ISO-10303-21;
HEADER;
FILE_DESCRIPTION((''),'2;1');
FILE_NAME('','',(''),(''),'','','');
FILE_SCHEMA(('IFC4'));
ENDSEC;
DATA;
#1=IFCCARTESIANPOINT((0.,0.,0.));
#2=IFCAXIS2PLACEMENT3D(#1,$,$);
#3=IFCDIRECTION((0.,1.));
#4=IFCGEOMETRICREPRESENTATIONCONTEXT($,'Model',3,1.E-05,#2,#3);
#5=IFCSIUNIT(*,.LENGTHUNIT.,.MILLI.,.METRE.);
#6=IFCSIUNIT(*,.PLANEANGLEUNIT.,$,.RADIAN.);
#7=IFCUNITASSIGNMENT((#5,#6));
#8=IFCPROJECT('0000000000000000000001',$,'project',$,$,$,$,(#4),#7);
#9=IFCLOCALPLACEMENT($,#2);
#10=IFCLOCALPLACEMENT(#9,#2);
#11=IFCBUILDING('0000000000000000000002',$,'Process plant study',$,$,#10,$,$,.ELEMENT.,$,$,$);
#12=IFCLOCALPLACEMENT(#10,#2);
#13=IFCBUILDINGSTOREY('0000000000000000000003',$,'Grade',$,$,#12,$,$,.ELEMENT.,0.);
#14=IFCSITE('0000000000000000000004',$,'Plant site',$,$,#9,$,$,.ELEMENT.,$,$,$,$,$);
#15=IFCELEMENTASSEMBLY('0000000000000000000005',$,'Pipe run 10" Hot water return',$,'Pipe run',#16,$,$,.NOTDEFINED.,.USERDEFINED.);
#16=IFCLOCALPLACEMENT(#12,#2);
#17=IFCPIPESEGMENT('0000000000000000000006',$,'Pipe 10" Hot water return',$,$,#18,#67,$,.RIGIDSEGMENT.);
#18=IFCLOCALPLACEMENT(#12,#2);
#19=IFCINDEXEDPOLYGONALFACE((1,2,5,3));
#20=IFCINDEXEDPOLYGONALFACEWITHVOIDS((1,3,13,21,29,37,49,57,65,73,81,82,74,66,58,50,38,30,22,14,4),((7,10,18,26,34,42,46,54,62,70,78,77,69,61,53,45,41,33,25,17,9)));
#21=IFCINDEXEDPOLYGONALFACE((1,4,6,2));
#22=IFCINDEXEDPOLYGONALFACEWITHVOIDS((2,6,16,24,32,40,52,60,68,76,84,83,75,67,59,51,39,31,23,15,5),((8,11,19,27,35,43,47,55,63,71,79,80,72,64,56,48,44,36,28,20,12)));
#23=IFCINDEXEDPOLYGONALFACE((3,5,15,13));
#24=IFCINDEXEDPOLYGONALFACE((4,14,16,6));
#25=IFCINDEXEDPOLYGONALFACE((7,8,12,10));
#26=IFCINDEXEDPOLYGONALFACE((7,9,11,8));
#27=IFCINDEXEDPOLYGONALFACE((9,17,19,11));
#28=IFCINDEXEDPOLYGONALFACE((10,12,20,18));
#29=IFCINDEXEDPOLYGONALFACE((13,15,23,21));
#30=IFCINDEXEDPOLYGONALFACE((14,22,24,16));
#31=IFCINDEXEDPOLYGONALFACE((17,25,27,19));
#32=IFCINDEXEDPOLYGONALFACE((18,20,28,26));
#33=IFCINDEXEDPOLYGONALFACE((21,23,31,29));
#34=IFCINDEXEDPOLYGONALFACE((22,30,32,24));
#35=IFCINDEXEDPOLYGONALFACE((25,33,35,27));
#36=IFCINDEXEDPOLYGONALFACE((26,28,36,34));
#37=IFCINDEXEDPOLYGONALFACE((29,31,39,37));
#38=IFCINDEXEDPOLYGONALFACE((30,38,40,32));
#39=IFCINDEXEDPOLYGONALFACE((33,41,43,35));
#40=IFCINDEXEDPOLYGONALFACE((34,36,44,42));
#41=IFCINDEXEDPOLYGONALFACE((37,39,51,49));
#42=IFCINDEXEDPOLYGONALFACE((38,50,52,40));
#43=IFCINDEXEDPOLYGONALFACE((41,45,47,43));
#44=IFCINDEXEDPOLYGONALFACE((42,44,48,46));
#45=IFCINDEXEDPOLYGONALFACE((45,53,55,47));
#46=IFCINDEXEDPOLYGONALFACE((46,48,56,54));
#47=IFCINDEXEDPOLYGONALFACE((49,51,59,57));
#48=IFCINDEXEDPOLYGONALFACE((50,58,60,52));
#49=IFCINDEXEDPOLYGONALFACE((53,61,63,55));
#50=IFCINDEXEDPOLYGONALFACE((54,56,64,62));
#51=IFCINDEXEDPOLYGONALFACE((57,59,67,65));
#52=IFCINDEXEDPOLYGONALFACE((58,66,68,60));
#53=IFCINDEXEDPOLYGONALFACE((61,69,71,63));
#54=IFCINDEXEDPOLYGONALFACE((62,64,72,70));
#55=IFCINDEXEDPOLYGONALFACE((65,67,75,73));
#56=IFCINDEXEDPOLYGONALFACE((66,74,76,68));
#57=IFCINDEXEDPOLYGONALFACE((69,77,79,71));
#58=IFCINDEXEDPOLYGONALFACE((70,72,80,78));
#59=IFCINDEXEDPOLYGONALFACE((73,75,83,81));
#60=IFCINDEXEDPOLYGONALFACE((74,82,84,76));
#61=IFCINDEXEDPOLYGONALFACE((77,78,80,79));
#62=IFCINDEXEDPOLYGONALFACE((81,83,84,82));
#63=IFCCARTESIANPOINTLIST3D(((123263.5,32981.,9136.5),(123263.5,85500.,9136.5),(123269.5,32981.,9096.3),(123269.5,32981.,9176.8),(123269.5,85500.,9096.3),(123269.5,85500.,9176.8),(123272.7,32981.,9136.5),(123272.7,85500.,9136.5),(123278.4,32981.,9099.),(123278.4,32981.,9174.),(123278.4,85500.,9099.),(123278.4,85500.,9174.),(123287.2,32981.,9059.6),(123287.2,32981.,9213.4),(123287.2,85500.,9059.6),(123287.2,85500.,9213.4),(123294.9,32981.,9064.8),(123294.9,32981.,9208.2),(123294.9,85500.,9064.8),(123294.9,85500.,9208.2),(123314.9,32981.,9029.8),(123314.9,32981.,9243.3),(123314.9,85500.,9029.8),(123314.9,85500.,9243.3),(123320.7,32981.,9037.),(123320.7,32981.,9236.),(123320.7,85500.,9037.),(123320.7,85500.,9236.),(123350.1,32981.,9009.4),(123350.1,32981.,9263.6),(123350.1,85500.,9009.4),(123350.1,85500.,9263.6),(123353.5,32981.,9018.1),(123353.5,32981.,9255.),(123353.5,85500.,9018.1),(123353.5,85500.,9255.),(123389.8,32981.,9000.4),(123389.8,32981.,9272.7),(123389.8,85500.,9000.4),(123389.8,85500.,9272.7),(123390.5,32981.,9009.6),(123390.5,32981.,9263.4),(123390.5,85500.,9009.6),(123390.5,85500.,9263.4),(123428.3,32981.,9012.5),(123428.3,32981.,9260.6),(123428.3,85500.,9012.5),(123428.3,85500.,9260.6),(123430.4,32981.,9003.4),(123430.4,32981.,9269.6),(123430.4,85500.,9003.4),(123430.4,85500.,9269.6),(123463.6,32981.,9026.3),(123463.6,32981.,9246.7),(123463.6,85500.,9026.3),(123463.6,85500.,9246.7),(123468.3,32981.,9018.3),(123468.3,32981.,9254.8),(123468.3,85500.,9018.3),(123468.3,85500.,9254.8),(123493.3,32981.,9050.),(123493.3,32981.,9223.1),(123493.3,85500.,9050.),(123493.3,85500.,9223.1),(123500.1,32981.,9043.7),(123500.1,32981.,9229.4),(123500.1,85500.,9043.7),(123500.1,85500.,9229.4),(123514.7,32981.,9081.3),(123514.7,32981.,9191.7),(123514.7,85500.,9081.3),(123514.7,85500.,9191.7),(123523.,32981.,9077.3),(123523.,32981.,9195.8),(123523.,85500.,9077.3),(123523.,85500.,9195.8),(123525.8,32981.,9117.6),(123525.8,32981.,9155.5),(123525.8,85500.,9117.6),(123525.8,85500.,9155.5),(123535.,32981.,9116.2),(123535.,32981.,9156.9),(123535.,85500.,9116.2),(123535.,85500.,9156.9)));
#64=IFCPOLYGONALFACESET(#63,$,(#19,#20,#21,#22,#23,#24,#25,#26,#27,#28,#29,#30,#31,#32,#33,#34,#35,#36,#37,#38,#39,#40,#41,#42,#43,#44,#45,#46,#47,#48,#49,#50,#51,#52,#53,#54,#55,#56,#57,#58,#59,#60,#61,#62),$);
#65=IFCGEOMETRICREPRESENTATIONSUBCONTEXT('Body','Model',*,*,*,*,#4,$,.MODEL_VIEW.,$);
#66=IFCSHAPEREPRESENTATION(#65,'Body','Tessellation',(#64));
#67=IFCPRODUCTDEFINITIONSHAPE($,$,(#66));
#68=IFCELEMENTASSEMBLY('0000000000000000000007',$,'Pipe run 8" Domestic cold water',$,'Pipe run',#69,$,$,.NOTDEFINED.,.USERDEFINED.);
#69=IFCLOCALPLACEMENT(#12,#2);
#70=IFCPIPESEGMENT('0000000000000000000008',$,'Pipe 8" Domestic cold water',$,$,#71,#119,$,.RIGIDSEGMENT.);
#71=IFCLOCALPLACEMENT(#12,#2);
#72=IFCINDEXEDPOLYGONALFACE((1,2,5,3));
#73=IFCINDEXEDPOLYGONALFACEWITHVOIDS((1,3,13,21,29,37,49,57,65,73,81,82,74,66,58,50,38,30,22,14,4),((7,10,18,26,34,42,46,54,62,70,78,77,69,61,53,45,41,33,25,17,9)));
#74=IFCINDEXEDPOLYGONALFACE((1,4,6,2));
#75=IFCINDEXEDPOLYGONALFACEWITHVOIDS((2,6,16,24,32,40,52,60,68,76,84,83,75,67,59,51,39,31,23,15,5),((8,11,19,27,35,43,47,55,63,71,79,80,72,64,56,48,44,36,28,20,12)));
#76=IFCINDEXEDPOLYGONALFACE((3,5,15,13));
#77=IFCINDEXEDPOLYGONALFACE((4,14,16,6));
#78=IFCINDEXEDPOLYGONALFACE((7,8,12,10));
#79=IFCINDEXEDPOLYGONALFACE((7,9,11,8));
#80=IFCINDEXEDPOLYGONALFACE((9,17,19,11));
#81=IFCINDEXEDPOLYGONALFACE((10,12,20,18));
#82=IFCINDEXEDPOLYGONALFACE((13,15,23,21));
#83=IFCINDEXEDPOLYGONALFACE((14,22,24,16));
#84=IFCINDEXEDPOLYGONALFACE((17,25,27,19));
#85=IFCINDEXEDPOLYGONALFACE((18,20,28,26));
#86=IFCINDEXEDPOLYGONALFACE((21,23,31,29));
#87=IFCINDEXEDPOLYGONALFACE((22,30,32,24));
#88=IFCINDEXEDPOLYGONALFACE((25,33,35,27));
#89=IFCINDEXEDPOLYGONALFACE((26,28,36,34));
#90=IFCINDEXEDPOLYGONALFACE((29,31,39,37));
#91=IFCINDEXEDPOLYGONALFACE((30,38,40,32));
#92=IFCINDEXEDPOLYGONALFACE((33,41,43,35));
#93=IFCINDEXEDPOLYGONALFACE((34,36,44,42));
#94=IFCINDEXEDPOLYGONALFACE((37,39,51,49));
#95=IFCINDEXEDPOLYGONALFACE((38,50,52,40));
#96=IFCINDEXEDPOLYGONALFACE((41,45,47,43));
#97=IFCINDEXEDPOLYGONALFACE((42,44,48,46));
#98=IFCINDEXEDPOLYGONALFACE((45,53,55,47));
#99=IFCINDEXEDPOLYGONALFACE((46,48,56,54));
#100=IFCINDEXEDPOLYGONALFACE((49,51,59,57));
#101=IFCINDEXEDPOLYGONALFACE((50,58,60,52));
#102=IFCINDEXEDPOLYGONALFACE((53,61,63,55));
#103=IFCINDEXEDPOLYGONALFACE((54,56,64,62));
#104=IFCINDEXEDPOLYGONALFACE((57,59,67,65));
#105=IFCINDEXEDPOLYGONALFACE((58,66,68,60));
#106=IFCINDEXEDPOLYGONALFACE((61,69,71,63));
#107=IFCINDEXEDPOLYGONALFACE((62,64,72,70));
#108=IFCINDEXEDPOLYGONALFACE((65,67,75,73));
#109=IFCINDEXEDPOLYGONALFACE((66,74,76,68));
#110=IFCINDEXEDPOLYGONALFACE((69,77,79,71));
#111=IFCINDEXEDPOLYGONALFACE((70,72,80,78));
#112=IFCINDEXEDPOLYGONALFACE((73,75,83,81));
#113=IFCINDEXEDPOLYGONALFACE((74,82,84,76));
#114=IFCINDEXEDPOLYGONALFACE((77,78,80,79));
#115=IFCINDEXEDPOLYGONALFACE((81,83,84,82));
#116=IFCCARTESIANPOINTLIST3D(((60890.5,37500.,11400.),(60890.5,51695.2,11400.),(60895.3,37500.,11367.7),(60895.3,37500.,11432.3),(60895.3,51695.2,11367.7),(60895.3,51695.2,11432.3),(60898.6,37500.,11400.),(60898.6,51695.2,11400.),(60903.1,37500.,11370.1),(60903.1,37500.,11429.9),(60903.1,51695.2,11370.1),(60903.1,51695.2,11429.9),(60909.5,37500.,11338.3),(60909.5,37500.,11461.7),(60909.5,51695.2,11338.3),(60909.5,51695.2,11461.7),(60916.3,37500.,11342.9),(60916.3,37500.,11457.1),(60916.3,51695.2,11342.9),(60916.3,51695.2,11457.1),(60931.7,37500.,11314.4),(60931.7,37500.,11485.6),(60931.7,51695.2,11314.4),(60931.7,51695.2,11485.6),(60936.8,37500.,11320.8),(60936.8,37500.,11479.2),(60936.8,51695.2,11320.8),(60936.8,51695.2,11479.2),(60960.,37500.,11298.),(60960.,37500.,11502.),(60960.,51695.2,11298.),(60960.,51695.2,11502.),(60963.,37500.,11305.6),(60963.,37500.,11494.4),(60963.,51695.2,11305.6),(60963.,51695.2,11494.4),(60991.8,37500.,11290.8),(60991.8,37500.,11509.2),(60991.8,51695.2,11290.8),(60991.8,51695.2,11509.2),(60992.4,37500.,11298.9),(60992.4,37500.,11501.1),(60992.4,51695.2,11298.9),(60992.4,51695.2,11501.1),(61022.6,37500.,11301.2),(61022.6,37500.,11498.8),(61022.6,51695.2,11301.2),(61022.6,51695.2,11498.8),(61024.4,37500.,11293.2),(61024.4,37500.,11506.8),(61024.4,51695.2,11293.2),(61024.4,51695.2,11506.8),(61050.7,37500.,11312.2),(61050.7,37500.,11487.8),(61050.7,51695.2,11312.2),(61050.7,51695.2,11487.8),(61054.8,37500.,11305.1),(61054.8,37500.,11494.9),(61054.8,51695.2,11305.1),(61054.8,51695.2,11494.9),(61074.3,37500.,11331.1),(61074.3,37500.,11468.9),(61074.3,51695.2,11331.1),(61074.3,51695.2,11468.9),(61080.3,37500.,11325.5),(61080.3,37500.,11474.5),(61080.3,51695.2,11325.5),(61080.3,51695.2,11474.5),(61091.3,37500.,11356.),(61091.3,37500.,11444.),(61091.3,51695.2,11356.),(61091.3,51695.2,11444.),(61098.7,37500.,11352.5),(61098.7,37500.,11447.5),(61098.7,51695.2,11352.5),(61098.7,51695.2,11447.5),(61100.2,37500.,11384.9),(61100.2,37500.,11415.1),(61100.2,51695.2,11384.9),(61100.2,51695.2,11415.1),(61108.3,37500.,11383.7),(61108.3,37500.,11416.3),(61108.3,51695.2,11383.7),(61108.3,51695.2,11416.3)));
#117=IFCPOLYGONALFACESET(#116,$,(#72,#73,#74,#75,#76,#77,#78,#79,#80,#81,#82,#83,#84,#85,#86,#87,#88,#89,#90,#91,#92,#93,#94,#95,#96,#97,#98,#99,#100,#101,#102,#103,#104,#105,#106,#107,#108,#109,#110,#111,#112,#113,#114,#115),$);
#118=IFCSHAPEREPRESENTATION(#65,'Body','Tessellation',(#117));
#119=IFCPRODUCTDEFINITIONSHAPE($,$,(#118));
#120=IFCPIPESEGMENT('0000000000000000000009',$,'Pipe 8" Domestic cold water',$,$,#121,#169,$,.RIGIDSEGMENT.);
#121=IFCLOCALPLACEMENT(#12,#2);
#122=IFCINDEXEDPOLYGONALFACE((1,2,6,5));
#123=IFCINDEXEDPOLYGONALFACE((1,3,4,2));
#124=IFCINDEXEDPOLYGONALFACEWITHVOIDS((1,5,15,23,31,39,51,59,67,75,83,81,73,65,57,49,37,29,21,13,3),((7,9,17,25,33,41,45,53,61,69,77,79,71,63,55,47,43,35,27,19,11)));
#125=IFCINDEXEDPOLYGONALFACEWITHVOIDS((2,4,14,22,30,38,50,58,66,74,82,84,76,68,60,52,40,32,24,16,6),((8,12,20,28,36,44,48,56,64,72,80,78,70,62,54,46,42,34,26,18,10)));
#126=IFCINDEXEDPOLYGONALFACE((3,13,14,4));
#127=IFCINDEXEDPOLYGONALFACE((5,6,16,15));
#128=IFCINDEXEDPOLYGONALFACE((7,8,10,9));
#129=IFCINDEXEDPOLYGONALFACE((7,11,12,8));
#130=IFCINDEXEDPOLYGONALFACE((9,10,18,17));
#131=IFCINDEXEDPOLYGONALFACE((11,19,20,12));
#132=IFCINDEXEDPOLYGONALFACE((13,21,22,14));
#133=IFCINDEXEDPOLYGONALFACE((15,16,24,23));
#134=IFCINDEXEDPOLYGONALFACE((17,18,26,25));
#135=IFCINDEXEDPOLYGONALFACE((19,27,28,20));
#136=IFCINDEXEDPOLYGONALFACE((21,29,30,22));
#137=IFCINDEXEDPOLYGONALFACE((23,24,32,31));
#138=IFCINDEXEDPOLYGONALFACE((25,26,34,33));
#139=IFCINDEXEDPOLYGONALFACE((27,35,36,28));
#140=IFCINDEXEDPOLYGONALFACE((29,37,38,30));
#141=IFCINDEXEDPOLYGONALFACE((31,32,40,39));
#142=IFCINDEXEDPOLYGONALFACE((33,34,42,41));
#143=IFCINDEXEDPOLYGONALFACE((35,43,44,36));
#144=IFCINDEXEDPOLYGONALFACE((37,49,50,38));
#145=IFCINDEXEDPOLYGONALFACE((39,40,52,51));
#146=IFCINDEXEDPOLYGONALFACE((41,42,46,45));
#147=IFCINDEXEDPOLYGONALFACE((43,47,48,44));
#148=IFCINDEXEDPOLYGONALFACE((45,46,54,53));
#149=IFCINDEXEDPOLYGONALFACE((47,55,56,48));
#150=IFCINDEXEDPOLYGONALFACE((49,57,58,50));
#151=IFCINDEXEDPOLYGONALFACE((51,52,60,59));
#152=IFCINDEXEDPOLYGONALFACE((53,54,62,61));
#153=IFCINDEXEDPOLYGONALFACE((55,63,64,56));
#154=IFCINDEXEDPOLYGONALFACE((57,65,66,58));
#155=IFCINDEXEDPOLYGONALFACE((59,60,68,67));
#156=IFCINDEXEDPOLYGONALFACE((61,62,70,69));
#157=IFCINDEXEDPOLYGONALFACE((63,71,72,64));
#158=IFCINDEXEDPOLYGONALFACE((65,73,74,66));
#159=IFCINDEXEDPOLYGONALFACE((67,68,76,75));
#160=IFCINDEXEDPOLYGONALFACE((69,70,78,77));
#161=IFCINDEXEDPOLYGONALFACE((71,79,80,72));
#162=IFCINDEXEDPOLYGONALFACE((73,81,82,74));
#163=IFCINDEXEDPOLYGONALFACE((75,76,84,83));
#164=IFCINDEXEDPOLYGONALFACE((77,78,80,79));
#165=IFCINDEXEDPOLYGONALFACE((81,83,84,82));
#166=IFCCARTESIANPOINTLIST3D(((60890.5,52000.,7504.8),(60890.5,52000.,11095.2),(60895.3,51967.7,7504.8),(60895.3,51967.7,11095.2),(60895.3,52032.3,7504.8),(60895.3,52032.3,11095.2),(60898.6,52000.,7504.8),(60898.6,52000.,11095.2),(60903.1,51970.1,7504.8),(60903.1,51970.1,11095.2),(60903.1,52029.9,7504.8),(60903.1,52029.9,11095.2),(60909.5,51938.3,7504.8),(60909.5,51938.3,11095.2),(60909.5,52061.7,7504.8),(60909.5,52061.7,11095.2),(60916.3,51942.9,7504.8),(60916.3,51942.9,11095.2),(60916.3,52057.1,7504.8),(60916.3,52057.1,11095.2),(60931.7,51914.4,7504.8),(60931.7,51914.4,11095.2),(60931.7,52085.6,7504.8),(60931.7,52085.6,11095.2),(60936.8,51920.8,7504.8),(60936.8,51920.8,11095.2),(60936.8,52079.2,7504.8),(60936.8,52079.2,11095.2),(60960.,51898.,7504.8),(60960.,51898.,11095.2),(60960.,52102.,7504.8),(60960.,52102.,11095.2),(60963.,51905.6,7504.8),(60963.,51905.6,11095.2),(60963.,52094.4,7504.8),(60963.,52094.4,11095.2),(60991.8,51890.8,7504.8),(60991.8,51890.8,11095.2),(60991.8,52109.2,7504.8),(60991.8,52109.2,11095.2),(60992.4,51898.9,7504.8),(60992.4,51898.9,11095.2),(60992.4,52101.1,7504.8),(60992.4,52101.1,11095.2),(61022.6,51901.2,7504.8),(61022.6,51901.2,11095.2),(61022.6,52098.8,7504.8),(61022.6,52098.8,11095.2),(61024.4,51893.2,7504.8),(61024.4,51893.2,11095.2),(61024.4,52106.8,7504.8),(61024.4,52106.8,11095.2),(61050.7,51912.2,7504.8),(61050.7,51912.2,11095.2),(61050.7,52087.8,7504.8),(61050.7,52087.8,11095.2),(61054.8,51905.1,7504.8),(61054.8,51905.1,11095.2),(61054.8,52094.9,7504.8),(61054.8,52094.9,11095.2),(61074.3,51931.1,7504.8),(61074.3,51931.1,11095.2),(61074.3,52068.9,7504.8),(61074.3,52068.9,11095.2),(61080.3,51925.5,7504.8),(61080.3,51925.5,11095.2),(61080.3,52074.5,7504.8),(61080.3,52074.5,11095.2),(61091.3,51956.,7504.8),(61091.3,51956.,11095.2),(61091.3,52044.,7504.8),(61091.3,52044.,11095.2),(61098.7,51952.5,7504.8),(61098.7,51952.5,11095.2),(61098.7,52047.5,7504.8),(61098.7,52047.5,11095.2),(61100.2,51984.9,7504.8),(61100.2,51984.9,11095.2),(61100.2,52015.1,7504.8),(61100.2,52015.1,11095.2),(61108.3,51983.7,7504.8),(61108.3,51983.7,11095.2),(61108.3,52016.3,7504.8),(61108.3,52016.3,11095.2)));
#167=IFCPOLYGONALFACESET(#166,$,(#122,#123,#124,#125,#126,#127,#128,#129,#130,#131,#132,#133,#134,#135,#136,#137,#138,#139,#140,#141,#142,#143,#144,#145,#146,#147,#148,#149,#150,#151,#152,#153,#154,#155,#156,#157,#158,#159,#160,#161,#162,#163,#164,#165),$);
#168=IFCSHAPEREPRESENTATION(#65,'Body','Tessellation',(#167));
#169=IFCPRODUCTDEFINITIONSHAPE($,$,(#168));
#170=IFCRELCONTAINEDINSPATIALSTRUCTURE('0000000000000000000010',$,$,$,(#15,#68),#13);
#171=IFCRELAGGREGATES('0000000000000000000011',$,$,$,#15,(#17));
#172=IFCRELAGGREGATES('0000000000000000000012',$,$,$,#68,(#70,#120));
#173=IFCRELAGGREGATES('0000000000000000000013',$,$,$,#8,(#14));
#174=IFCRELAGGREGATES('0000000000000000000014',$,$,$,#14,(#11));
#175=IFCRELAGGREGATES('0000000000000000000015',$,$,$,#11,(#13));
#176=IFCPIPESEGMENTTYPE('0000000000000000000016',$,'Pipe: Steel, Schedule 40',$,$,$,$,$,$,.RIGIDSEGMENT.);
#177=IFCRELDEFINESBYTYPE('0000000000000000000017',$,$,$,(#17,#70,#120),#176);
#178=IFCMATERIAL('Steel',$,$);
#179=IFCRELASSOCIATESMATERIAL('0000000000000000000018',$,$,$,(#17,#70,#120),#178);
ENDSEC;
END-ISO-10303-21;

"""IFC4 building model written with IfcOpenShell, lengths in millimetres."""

from ifc_helpers import new_model, si_unit, direction, frame, origin, origin_with_axes, origin_2d, place, context, subcontext, project, spatial, hollow_circle, extrude, material, type_object, element, aggregate, save


model = new_model("IFC4")

# Units and contexts
model_context = context("Model", 3, precision=1e-05, world=origin(), true_north=direction((0.0, 1.0)))
body_context = subcontext(model_context, "Body", "Model", "MODEL_VIEW")
ifc_project = project(units=[si_unit("LENGTHUNIT", "METRE", prefix="MILLI"), si_unit("PLANEANGLEUNIT", "RADIAN")], contexts=[model_context])

# Site, building, storey
site_placement = place(None, origin())
site = spatial("IfcSite", under=ifc_project, at=site_placement, Name="Plant site", CompositionType="ELEMENT")
building_placement = place(site_placement, origin())
building = spatial("IfcBuilding", under=site, at=building_placement, Name="Process plant study", CompositionType="ELEMENT")
storey_placement = place(building_placement, origin())
storey = spatial("IfcBuildingStorey", under=building, at=storey_placement, Name="Grade", CompositionType="ELEMENT", Elevation=0.0)

# Shared definitions
ifc_material = material(Name="Steel")
pipe_segment_type = type_object("IfcPipeSegmentType", Name="Pipe: Steel, Schedule 40", PredefinedType="RIGIDSEGMENT")

# Element assemblies, pipe segments
assembly_1_placement = place(storey_placement, origin_with_axes())
assembly_1 = element("IfcElementAssembly", 1, at=assembly_1_placement, inside=storey, Name="Pipe run 10\" Hot water return", ObjectType="Pipe run", AssemblyPlace="NOTDEFINED", PredefinedType="USERDEFINED")
pipe_segment_1_placement = place(storey_placement, origin_with_axes())
pipe_segment_1 = element("IfcPipeSegment", 2, at=pipe_segment_1_placement, type_object=pipe_segment_type, material=ifc_material, Name="Pipe 10\" Hot water return", PredefinedType="RIGIDSEGMENT", context=body_context, shape_type="SweptSolid", body=[
    extrude(hollow_circle(Radius=136.5, WallThickness=9.3, at=origin_2d()), frame((123400.0, 32981.0, 9136.5), z_axis=(0.0, 1.0, 0.0), x_axis=(-1.0, 0.0, 0.0)), (0.0, 0.0, 1.0), 52519.0),
])
assembly_2_placement = place(storey_placement, origin_with_axes())
assembly_2 = element("IfcElementAssembly", 3, at=assembly_2_placement, inside=storey, Name="Pipe run 8\" Domestic cold water", ObjectType="Pipe run", AssemblyPlace="NOTDEFINED", PredefinedType="USERDEFINED")
pipe_segment_2_placement = place(storey_placement, origin_with_axes())
pipe_segment_2 = element("IfcPipeSegment", 4, at=pipe_segment_2_placement, type_object=pipe_segment_type, material=ifc_material, Name="Pipe 8\" Domestic cold water", PredefinedType="RIGIDSEGMENT", context=body_context, shape_type="SweptSolid", body=[
    extrude(hollow_circle(Radius=109.5, WallThickness=8.2, at=origin_2d()), frame((61000.0, 37500.0, 11400.0), z_axis=(0.0, 1.0, 0.0), x_axis=(-1.0, 0.0, 0.0)), (0.0, 0.0, 1.0), 14195.2),
])
pipe_segment_3_placement = place(storey_placement, origin_with_axes())
pipe_segment_3 = element("IfcPipeSegment", 5, at=pipe_segment_3_placement, type_object=pipe_segment_type, material=ifc_material, Name="Pipe 8\" Domestic cold water", PredefinedType="RIGIDSEGMENT", context=body_context, shape_type="SweptSolid", body=[
    extrude(hollow_circle(Radius=109.5, WallThickness=8.2, at=origin_2d()), frame((61000.0, 52000.0, 11095.2), z_axis=(0.0, 0.0, -1.0), x_axis=(-1.0, 0.0, 0.0)), (0.0, 0.0, 1.0), 3590.4),
])

aggregate(assembly_1, [pipe_segment_1])
aggregate(assembly_2, [pipe_segment_2, pipe_segment_3])

save(model, "model.ifc")
